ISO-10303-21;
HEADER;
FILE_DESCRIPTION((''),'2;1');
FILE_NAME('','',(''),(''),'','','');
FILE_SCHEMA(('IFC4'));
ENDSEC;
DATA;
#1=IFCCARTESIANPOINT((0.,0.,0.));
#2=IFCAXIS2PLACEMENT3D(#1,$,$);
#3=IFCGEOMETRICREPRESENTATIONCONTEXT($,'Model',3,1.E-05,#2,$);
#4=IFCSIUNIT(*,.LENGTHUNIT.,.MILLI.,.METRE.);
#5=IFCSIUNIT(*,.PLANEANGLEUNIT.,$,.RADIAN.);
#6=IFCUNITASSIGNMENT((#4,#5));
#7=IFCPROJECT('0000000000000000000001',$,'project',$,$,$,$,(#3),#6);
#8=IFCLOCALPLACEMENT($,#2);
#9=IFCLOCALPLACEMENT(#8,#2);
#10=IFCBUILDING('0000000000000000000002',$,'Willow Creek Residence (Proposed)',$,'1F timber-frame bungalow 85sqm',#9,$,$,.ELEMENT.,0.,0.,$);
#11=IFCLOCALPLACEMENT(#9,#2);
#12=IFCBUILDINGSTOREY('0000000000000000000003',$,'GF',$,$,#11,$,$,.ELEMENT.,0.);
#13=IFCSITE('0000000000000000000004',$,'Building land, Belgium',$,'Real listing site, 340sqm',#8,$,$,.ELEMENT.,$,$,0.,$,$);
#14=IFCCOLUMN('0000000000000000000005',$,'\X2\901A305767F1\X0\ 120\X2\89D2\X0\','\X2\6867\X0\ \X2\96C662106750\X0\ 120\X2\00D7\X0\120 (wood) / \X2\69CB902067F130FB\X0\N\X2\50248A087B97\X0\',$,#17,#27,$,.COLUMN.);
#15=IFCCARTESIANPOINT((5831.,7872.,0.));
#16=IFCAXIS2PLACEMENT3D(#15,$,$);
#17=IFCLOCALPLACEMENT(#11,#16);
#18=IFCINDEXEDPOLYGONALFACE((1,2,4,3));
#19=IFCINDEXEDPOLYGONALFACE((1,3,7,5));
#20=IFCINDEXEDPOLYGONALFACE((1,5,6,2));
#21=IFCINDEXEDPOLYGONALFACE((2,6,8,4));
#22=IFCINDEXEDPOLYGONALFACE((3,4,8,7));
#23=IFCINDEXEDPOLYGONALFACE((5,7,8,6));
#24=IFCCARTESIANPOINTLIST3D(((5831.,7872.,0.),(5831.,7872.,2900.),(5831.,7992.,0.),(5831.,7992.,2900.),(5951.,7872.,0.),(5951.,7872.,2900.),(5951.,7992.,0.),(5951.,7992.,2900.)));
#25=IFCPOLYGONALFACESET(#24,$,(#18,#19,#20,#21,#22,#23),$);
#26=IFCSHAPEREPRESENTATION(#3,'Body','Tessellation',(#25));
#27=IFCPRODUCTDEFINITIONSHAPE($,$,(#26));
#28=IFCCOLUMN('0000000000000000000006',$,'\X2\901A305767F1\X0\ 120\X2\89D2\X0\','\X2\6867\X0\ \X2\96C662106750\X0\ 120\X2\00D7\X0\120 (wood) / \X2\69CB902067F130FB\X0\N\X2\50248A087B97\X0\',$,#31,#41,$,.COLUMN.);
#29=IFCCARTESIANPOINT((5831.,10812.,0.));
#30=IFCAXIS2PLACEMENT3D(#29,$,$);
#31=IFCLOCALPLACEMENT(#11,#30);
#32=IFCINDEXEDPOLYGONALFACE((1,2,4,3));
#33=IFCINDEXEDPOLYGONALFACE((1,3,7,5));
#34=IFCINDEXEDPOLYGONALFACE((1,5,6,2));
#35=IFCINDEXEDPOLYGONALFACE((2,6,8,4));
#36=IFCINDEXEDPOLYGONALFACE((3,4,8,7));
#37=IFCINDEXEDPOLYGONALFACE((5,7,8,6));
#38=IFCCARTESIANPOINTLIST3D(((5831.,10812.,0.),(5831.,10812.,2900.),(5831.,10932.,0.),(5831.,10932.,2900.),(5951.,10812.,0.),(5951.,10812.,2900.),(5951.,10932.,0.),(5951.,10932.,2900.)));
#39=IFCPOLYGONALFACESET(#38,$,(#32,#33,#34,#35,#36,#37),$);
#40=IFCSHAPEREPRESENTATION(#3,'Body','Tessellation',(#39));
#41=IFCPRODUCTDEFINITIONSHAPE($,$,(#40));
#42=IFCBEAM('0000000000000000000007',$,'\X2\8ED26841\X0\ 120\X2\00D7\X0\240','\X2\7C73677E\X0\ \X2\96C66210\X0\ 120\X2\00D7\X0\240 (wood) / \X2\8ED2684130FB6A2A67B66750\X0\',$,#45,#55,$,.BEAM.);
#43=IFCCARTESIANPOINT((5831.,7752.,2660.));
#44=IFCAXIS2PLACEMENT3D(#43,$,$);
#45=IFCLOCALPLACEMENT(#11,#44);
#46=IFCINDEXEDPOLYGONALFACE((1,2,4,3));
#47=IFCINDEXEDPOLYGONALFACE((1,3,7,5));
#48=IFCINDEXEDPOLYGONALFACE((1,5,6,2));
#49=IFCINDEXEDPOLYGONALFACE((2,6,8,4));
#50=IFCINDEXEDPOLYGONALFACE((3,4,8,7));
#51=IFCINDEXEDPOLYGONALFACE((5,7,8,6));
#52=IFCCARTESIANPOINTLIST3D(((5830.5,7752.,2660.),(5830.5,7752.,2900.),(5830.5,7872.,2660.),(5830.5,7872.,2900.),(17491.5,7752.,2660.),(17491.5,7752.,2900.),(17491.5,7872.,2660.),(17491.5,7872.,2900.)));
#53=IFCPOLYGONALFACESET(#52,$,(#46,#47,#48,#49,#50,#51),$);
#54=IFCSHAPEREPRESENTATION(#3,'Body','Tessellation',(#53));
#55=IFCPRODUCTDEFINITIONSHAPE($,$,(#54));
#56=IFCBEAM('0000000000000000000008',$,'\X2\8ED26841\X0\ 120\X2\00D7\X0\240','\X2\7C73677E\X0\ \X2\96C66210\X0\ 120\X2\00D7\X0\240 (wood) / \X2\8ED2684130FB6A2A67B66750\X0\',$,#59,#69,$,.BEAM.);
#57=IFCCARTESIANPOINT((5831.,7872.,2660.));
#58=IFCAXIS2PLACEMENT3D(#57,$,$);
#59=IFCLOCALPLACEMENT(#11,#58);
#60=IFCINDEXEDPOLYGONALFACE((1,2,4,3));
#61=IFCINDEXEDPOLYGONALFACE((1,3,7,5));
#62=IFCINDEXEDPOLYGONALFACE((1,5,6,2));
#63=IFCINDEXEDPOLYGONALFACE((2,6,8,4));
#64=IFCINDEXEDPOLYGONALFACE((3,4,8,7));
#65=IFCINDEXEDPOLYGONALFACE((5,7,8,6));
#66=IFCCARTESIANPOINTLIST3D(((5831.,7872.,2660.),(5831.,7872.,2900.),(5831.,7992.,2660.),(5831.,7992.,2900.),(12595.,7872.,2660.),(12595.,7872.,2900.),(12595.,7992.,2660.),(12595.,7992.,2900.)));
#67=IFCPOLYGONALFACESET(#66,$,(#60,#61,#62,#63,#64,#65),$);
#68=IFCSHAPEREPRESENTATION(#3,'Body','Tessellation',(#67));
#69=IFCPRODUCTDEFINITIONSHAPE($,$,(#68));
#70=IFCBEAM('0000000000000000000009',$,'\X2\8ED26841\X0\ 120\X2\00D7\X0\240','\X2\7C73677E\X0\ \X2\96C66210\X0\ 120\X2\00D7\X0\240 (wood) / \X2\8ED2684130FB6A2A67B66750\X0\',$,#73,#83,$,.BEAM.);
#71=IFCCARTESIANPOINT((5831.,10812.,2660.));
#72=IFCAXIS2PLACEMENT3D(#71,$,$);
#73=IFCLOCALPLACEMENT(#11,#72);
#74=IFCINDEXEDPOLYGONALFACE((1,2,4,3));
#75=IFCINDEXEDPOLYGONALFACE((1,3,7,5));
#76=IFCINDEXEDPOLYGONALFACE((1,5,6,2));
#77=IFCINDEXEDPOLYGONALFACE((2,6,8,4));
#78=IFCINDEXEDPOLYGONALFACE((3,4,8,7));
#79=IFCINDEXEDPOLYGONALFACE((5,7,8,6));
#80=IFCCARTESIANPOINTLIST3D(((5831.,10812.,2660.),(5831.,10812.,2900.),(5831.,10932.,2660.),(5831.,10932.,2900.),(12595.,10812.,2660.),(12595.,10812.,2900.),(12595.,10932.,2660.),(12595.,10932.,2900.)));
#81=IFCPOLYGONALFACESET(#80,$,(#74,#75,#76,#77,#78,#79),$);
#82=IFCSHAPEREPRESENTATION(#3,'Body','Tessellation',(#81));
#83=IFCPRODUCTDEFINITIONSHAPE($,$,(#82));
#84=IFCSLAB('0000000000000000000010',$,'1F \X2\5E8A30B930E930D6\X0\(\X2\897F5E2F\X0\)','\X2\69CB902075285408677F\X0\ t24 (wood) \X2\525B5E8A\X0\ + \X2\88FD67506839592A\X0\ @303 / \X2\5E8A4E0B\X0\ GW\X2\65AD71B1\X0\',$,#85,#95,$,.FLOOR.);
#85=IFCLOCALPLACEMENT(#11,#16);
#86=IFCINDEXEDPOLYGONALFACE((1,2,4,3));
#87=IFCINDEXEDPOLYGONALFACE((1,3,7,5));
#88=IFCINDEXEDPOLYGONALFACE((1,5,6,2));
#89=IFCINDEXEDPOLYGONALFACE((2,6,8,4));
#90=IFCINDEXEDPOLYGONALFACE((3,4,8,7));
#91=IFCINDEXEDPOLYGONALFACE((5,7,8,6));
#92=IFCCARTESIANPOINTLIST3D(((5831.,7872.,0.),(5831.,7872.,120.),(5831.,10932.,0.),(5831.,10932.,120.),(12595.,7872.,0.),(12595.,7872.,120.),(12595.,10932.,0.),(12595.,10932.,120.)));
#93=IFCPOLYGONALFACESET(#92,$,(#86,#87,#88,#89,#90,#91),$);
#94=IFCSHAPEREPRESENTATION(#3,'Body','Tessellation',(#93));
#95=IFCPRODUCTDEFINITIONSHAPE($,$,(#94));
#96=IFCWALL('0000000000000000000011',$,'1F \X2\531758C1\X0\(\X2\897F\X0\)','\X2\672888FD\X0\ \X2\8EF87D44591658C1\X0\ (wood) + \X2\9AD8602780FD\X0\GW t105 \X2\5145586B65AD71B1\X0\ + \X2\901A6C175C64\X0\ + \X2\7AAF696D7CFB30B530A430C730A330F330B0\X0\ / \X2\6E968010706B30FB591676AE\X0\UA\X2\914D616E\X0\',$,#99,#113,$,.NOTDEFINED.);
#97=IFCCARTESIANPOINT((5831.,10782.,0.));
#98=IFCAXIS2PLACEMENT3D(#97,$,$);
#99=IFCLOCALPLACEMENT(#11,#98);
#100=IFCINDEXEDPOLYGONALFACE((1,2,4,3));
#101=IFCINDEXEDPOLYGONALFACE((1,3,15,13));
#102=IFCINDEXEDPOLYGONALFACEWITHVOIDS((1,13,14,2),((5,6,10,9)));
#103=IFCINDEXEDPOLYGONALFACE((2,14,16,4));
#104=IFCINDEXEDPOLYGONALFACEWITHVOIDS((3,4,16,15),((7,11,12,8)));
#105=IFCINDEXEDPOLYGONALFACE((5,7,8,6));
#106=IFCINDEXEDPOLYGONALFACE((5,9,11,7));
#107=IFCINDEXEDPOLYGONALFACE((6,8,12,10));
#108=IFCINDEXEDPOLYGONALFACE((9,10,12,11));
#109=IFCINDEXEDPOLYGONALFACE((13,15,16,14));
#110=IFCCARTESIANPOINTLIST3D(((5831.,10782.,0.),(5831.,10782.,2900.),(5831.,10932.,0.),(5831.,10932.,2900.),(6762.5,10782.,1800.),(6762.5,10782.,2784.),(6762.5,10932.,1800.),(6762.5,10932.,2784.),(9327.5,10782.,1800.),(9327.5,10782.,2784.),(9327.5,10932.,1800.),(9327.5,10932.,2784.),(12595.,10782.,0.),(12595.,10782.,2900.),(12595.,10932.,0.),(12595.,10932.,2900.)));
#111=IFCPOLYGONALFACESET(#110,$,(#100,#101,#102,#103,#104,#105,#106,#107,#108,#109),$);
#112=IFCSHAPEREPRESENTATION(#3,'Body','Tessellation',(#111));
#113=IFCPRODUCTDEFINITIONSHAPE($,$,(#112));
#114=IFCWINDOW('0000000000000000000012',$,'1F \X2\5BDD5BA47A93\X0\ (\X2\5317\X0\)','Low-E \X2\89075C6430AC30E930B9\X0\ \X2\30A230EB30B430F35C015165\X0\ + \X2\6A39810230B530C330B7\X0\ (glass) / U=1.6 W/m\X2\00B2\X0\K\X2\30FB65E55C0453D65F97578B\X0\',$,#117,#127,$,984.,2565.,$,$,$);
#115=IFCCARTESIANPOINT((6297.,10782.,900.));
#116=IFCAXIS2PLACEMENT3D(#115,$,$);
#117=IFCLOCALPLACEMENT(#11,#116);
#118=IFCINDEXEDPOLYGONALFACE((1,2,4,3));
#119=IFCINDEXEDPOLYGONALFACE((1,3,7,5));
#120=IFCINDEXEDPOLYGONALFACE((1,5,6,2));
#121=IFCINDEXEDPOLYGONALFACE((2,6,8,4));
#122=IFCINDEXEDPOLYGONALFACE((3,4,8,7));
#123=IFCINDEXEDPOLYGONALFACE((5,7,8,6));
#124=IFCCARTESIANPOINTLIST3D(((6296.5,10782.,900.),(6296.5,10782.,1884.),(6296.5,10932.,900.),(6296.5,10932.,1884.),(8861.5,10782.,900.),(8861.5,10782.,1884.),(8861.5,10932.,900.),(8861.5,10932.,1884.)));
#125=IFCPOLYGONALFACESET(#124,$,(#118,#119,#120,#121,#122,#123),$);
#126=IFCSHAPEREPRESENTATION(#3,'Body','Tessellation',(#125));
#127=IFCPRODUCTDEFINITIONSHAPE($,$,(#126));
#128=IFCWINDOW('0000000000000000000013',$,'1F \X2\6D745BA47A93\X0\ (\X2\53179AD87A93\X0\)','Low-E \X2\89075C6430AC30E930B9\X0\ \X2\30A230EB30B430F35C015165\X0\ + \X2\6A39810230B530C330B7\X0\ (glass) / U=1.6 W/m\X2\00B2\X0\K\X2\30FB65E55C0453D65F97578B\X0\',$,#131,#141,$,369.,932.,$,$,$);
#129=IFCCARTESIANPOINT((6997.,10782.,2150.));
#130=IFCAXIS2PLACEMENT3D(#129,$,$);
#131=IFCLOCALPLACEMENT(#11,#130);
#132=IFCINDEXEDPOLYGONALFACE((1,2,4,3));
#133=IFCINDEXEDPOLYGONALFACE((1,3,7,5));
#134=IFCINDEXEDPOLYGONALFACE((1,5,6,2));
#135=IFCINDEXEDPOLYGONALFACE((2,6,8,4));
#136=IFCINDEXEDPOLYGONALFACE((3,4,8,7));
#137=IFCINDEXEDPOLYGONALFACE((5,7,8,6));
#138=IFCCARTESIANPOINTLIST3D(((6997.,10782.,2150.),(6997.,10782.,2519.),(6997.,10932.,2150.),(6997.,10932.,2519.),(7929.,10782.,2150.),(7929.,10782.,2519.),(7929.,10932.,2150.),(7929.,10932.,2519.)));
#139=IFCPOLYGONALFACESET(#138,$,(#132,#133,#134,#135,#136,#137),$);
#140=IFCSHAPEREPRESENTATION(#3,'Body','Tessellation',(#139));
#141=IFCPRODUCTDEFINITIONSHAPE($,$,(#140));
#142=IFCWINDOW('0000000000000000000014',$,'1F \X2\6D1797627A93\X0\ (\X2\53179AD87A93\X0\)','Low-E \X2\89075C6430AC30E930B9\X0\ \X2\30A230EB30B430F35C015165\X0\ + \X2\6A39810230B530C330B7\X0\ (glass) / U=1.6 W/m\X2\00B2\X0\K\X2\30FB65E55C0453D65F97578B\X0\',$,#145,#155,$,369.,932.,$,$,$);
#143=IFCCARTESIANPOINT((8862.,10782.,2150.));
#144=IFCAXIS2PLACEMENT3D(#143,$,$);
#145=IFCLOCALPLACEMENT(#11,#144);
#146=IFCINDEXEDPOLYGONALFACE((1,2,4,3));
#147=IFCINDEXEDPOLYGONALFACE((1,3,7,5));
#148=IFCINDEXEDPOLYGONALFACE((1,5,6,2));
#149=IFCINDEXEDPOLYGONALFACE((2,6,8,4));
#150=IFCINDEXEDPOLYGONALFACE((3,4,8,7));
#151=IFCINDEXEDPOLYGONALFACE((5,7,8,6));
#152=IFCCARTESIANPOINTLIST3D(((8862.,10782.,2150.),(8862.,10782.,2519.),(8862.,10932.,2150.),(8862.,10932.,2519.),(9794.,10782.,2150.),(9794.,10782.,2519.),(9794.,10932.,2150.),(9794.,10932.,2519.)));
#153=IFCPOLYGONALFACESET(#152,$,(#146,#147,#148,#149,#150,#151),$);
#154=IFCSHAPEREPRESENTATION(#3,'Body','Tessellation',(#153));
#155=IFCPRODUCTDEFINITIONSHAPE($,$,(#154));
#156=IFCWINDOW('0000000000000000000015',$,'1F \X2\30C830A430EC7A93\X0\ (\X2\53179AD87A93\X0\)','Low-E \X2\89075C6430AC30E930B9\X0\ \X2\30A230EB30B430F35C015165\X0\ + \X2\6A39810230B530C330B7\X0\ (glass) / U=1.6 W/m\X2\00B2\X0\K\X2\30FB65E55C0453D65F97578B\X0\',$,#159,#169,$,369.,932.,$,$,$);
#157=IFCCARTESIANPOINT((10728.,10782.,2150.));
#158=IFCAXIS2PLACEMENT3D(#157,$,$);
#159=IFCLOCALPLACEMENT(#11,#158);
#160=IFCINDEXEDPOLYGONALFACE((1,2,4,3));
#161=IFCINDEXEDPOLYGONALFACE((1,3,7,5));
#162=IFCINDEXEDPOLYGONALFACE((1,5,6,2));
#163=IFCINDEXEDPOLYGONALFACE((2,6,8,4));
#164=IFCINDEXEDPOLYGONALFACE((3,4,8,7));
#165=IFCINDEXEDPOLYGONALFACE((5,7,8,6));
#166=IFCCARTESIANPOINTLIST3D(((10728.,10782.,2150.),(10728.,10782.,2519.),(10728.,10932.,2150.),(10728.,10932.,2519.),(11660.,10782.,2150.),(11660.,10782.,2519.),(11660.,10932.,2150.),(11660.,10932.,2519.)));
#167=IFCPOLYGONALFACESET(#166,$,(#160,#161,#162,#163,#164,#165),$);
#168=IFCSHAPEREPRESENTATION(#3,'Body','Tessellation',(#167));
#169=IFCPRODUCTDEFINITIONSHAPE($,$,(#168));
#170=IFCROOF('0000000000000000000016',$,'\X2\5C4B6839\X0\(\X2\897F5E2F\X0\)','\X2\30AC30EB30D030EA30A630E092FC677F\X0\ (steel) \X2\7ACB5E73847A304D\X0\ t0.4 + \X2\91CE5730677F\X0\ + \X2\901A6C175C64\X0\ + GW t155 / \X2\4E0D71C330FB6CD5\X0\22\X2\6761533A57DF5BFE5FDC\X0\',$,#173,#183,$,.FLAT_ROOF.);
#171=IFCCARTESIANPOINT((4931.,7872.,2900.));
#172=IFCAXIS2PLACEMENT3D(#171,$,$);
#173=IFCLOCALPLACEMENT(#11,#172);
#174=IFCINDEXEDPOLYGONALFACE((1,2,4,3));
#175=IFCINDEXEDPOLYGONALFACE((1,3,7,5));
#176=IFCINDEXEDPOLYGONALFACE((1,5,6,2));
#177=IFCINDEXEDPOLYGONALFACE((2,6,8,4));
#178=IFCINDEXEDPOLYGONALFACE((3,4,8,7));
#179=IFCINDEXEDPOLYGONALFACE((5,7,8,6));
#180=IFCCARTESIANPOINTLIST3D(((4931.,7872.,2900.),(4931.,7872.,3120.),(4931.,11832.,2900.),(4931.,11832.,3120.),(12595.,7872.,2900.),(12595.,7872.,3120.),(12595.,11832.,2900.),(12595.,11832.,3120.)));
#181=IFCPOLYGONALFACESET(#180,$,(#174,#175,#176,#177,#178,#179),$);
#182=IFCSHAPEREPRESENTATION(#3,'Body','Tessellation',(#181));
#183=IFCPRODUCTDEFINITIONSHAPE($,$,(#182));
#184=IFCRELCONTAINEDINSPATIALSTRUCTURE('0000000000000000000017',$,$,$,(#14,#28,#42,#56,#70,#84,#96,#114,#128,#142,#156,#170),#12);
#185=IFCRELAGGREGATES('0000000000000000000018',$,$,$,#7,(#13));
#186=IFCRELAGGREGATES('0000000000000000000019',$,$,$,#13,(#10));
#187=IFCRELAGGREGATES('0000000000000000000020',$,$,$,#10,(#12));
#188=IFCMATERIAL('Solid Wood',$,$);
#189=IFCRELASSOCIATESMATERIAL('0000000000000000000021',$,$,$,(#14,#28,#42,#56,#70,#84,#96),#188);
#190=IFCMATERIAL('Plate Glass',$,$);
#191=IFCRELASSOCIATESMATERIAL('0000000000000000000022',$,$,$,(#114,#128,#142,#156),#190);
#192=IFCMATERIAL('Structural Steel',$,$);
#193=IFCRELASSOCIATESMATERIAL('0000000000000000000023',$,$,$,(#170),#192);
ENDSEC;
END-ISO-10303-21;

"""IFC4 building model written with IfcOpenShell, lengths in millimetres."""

from ifc_helpers import new_model, si_unit, frame, frame_2d, origin, place, context, project, spatial, rectangle, extrude, material, element, fill, save


model = new_model("IFC4")

# Units and contexts
model_context = context("Model", 3, precision=1e-05, world=origin())
ifc_project = project(units=[si_unit("LENGTHUNIT", "METRE", prefix="MILLI"), si_unit("PLANEANGLEUNIT", "RADIAN")], contexts=[model_context])

# Site, building, storey
site_placement = place(None, origin())
site = spatial("IfcSite", under=ifc_project, at=site_placement, Name="Building land, Belgium", ObjectType="Real listing site, 340sqm", CompositionType="ELEMENT", RefElevation=0.0)
building_placement = place(site_placement, origin())
building = spatial("IfcBuilding", under=site, at=building_placement, Name="Willow Creek Residence (Proposed)", ObjectType="1F timber-frame bungalow 85sqm", CompositionType="ELEMENT", ElevationOfRefHeight=0.0, ElevationOfTerrain=0.0)
storey_placement = place(building_placement, origin())
storey = spatial("IfcBuildingStorey", under=building, at=storey_placement, Name="GF", CompositionType="ELEMENT", Elevation=0.0)

# Columns
ifc_material_1 = material(Name="Solid Wood")
column_1_placement = place(storey_placement, frame((5831.0, 7872.0, 0.0)))
element("IfcColumn", 1, at=column_1_placement, inside=storey, material=ifc_material_1, Name="通し柱 120角", Description="桧 集成材 120×120 (wood) / 構造柱・N値計算", PredefinedType="COLUMN", context=model_context, shape_type="SweptSolid", body=[
    extrude(rectangle(XDim=120.0, YDim=120.0, at=frame_2d((60.0, 60.0))), frame((5831.0, 7872.0, 0.0)), (0.0, 0.0, 1.0), 2900.0),
])
column_2_placement = place(storey_placement, frame((5831.0, 10812.0, 0.0)))
element("IfcColumn", 2, at=column_2_placement, inside=storey, material=ifc_material_1, Name="通し柱 120角", Description="桧 集成材 120×120 (wood) / 構造柱・N値計算", PredefinedType="COLUMN", context=model_context, shape_type="SweptSolid", body=[
    extrude(rectangle(XDim=120.0, YDim=120.0, at=frame_2d((60.0, 60.0))), frame((5831.0, 10812.0, 0.0)), (0.0, 0.0, 1.0), 2900.0),
])

# Beams
beam_1_placement = place(storey_placement, frame((5831.0, 7752.0, 2660.0)))
element("IfcBeam", 3, at=beam_1_placement, inside=storey, material=ifc_material_1, Name="軒桁 120×240", Description="米松 集成 120×240 (wood) / 軒桁・横架材", PredefinedType="BEAM", context=model_context, shape_type="SweptSolid", body=[
    extrude(rectangle(XDim=11661.0, YDim=120.0, at=frame_2d((5830.0, 60.0))), frame((5831.0, 7752.0, 2660.0)), (0.0, 0.0, 1.0), 240.0),
])
beam_2_placement = place(storey_placement, frame((5831.0, 7872.0, 2660.0)))
element("IfcBeam", 4, at=beam_2_placement, inside=storey, material=ifc_material_1, Name="軒桁 120×240", Description="米松 集成 120×240 (wood) / 軒桁・横架材", PredefinedType="BEAM", context=model_context, shape_type="SweptSolid", body=[
    extrude(rectangle(XDim=6764.0, YDim=120.0, at=frame_2d((3382.0, 60.0))), frame((5831.0, 7872.0, 2660.0)), (0.0, 0.0, 1.0), 240.0),
])
beam_3_placement = place(storey_placement, frame((5831.0, 10812.0, 2660.0)))
element("IfcBeam", 5, at=beam_3_placement, inside=storey, material=ifc_material_1, Name="軒桁 120×240", Description="米松 集成 120×240 (wood) / 軒桁・横架材", PredefinedType="BEAM", context=model_context, shape_type="SweptSolid", body=[
    extrude(rectangle(XDim=6764.0, YDim=120.0, at=frame_2d((3382.0, 60.0))), frame((5831.0, 10812.0, 2660.0)), (0.0, 0.0, 1.0), 240.0),
])

# Slab
slab_placement = place(storey_placement, frame((5831.0, 7872.0, 0.0)))
element("IfcSlab", 6, at=slab_placement, inside=storey, material=ifc_material_1, Name="1F 床スラブ(西帯)", Description="構造用合板 t24 (wood) 剛床 + 製材根太 @303 / 床下 GW断熱", PredefinedType="FLOOR", context=model_context, shape_type="SweptSolid", body=[
    extrude(rectangle(XDim=6764.0, YDim=3060.0, at=frame_2d((3382.0, 1530.0))), frame((5831.0, 7872.0, 0.0)), (0.0, 0.0, 1.0), 120.0),
])

# Wall, openings, windows
wall_1_placement = place(storey_placement, frame((5831.0, 10782.0, 0.0)))
wall_1 = element("IfcWall", 7, at=wall_1_placement, inside=storey, material=ifc_material_1, Name="1F 北壁(西)", Description="木製 軸組外壁 (wood) + 高性能GW t105 充填断熱 + 通気層 + 窯業系サイディング / 準耐火・外皮UA配慮", PredefinedType="NOTDEFINED", context=model_context, shape_type="SweptSolid", body=[
    extrude(rectangle(XDim=6764.0, YDim=150.0, at=frame_2d((3382.0, 75.0))), frame((5831.0, 10782.0, 0.0)), (0.0, 0.0, 1.0), 2900.0),
])
opening_1_placement = place(storey_placement, frame((6297.0, 10782.0, 900.0)))
opening_1 = element("IfcOpeningElement", 8, at=opening_1_placement, cuts=wall_1, PredefinedType="NOTDEFINED", context=model_context, shape_type="SweptSolid", body=[
    extrude(rectangle(XDim=2565.0, YDim=150.0, at=frame_2d((1282.0, 75.0))), frame((6297.0, 10782.0, 900.0)), (0.0, 0.0, 1.0), 984.0),
])
opening_2_placement = place(storey_placement, frame((6997.0, 10782.0, 2150.0)))
opening_2 = element("IfcOpeningElement", 9, at=opening_2_placement, cuts=wall_1, PredefinedType="NOTDEFINED", context=model_context, shape_type="SweptSolid", body=[
    extrude(rectangle(XDim=932.0, YDim=150.0, at=frame_2d((466.0, 75.0))), frame((6997.0, 10782.0, 2150.0)), (0.0, 0.0, 1.0), 369.0),
])
opening_3_placement = place(storey_placement, frame((8862.0, 10782.0, 2150.0)))
opening_3 = element("IfcOpeningElement", 10, at=opening_3_placement, cuts=wall_1, PredefinedType="NOTDEFINED", context=model_context, shape_type="SweptSolid", body=[
    extrude(rectangle(XDim=932.0, YDim=150.0, at=frame_2d((466.0, 75.0))), frame((8862.0, 10782.0, 2150.0)), (0.0, 0.0, 1.0), 369.0),
])
opening_4_placement = place(storey_placement, frame((10728.0, 10782.0, 2150.0)))
opening_4 = element("IfcOpeningElement", 11, at=opening_4_placement, cuts=wall_1, PredefinedType="NOTDEFINED", context=model_context, shape_type="SweptSolid", body=[
    extrude(rectangle(XDim=932.0, YDim=150.0, at=frame_2d((466.0, 75.0))), frame((10728.0, 10782.0, 2150.0)), (0.0, 0.0, 1.0), 369.0),
])
ifc_material_2 = material(Name="Plate Glass")
window_1_placement = place(storey_placement, frame((6297.0, 10782.0, 900.0)))
window_1 = element("IfcWindow", 12, at=window_1_placement, inside=storey, material=ifc_material_2, Name="1F 寝室窓 (北)", Description="Low-E 複層ガラス アルゴン封入 + 樹脂サッシ (glass) / U=1.6 W/m²K・日射取得型", OverallHeight=984.0, OverallWidth=2565.0, context=model_context, shape_type="SweptSolid", body=[
    extrude(rectangle(XDim=2565.0, YDim=150.0, at=frame_2d((1282.0, 75.0))), frame((6297.0, 10782.0, 900.0)), (0.0, 0.0, 1.0), 984.0),
])
fill(opening_1, window_1)
window_2_placement = place(storey_placement, frame((6997.0, 10782.0, 2150.0)))
window_2 = element("IfcWindow", 13, at=window_2_placement, inside=storey, material=ifc_material_2, Name="1F 浴室窓 (北高窓)", Description="Low-E 複層ガラス アルゴン封入 + 樹脂サッシ (glass) / U=1.6 W/m²K・日射取得型", OverallHeight=369.0, OverallWidth=932.0, context=model_context, shape_type="SweptSolid", body=[
    extrude(rectangle(XDim=932.0, YDim=150.0, at=frame_2d((466.0, 75.0))), frame((6997.0, 10782.0, 2150.0)), (0.0, 0.0, 1.0), 369.0),
])
fill(opening_2, window_2)
window_3_placement = place(storey_placement, frame((8862.0, 10782.0, 2150.0)))
window_3 = element("IfcWindow", 14, at=window_3_placement, inside=storey, material=ifc_material_2, Name="1F 洗面窓 (北高窓)", Description="Low-E 複層ガラス アルゴン封入 + 樹脂サッシ (glass) / U=1.6 W/m²K・日射取得型", OverallHeight=369.0, OverallWidth=932.0, context=model_context, shape_type="SweptSolid", body=[
    extrude(rectangle(XDim=932.0, YDim=150.0, at=frame_2d((466.0, 75.0))), frame((8862.0, 10782.0, 2150.0)), (0.0, 0.0, 1.0), 369.0),
])
fill(opening_3, window_3)
window_4_placement = place(storey_placement, frame((10728.0, 10782.0, 2150.0)))
window_4 = element("IfcWindow", 15, at=window_4_placement, inside=storey, material=ifc_material_2, Name="1F トイレ窓 (北高窓)", Description="Low-E 複層ガラス アルゴン封入 + 樹脂サッシ (glass) / U=1.6 W/m²K・日射取得型", OverallHeight=369.0, OverallWidth=932.0, context=model_context, shape_type="SweptSolid", body=[
    extrude(rectangle(XDim=932.0, YDim=150.0, at=frame_2d((466.0, 75.0))), frame((10728.0, 10782.0, 2150.0)), (0.0, 0.0, 1.0), 369.0),
])
fill(opening_4, window_4)

# Roof
ifc_material_3 = material(Name="Structural Steel")
roof_placement = place(storey_placement, frame((4931.0, 7872.0, 2900.0)))
element("IfcRoof", 16, at=roof_placement, inside=storey, material=ifc_material_3, Name="屋根(西帯)", Description="ガルバリウム鋼板 (steel) 立平葺き t0.4 + 野地板 + 通気層 + GW t155 / 不燃・法22条区域対応", PredefinedType="FLAT_ROOF", context=model_context, shape_type="SweptSolid", body=[
    extrude(rectangle(XDim=7664.0, YDim=3960.0, at=frame_2d((3832.0, 1980.0))), frame((4931.0, 7872.0, 2900.0)), (0.0, 0.0, 1.0), 220.0),
])

save(model, "model.ifc")
